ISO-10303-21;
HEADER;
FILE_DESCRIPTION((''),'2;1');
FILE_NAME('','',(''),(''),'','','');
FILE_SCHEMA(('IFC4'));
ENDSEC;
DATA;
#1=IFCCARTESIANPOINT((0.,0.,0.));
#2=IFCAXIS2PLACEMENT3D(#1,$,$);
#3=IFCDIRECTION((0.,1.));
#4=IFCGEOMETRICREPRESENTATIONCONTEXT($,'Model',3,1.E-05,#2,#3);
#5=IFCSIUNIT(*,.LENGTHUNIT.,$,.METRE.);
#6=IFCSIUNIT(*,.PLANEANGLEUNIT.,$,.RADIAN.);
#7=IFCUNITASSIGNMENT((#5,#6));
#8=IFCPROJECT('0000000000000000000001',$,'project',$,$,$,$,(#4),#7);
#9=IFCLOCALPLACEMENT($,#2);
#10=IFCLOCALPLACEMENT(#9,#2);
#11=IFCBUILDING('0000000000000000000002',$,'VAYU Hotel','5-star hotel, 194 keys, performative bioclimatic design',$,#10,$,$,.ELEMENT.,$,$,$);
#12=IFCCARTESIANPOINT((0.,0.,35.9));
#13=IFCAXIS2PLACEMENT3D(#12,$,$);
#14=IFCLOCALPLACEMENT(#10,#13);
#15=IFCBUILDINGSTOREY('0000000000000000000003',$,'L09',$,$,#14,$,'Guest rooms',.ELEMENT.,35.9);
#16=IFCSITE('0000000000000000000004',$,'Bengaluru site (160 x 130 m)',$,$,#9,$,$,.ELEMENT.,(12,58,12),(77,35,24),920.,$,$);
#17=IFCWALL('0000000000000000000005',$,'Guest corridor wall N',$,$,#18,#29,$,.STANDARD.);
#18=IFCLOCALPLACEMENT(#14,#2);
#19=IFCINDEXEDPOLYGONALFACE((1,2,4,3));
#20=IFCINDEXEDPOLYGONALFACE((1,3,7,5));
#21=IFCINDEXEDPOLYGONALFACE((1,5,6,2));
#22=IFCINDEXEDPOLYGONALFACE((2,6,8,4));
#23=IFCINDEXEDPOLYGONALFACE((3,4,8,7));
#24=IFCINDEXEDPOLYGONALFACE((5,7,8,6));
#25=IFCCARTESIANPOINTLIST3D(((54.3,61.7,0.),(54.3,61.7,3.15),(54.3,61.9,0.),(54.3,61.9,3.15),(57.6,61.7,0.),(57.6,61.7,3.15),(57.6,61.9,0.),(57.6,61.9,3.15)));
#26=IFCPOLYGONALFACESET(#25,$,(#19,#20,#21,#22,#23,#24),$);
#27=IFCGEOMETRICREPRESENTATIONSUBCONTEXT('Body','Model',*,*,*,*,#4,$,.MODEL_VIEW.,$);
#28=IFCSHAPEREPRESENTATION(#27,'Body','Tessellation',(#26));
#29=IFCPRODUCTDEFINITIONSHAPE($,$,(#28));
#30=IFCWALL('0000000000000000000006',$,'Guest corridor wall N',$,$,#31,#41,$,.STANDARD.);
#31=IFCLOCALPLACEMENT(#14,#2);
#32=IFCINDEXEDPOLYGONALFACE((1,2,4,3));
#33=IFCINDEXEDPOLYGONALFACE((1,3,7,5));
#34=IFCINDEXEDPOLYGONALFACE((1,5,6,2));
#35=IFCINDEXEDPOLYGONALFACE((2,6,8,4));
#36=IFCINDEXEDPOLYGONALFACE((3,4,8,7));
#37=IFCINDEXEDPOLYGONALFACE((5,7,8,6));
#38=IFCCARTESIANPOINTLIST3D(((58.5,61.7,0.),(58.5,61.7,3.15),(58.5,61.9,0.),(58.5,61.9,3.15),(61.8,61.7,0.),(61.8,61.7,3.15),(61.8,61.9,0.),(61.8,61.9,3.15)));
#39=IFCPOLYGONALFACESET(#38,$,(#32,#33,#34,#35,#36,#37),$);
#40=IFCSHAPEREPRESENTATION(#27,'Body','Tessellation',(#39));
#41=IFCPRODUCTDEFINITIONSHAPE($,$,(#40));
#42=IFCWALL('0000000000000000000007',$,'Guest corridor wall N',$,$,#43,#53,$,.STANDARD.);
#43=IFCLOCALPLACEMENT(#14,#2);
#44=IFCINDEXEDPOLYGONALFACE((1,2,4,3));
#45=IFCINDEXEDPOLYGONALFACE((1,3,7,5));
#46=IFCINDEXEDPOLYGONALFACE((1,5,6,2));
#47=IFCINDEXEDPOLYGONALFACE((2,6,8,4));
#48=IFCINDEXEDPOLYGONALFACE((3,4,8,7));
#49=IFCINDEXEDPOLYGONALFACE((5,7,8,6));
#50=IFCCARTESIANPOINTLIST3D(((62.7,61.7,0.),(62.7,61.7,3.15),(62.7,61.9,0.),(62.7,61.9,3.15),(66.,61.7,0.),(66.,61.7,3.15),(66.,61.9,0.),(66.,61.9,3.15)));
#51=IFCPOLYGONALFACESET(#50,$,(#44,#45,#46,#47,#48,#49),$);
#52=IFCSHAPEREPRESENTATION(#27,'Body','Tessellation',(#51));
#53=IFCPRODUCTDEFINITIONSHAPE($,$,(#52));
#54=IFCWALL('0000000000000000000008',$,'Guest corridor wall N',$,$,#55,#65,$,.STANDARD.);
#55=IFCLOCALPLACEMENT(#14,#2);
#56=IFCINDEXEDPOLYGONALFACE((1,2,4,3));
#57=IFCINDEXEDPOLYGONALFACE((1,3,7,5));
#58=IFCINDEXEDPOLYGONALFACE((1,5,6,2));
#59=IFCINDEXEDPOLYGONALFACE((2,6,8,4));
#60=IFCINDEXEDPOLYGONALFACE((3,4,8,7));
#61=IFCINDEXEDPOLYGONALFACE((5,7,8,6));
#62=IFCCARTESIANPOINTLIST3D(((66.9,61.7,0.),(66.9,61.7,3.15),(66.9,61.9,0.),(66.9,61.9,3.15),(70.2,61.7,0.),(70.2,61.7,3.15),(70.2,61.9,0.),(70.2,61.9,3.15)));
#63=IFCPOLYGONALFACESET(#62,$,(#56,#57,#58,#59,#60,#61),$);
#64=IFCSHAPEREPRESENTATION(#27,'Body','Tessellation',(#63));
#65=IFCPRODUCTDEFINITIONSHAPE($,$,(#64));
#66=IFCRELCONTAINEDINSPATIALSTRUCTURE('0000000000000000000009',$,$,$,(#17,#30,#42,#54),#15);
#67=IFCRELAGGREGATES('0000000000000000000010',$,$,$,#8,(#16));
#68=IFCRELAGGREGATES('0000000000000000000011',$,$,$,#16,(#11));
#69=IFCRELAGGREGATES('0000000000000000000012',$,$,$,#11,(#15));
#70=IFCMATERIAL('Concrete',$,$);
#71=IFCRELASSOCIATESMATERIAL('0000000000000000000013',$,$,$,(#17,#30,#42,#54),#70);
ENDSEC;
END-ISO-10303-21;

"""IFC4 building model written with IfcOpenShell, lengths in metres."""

from ifc_helpers import new_model, si_unit, direction, frame, origin, place, context, subcontext, project, spatial, polyline, outline, extrude, material, element, save


model = new_model("IFC4")

# Units and contexts
model_context = context("Model", 3, precision=1e-05, world=origin(), true_north=direction((0.0, 1.0)))
body_context = subcontext(model_context, "Body", "Model", "MODEL_VIEW")
ifc_project = project(units=[si_unit("LENGTHUNIT", "METRE"), si_unit("PLANEANGLEUNIT", "RADIAN")], contexts=[model_context])

# Site, building, storey
site_placement = place(None, origin())
site = spatial("IfcSite", under=ifc_project, at=site_placement, Name="Bengaluru site (160 x 130 m)", CompositionType="ELEMENT", RefLatitude=(12, 58, 12), RefLongitude=(77, 35, 24), RefElevation=920.0)
building_placement = place(site_placement, origin())
building = spatial("IfcBuilding", under=site, at=building_placement, Name="VAYU Hotel", Description="5-star hotel, 194 keys, performative bioclimatic design", CompositionType="ELEMENT")
storey_placement = place(building_placement, frame((0.0, 0.0, 35.9)))
storey = spatial("IfcBuildingStorey", under=building, at=storey_placement, Name="L09", LongName="Guest rooms", CompositionType="ELEMENT", Elevation=35.9)

# Shared definitions
ifc_material = material(Name="Concrete")

# Walls
wall_1_placement = place(storey_placement, origin())
element("IfcWall", 1, at=wall_1_placement, inside=storey, material=ifc_material, Name="Guest corridor wall N", PredefinedType="STANDARD", context=body_context, shape_type="SweptSolid", body=[
    extrude(outline(polyline([(54.3, 61.9), (57.6, 61.9), (57.6, 61.7), (54.3, 61.7), (54.3, 61.9)])), origin(), (0.0, 0.0, 1.0), 3.15),
])
wall_2_placement = place(storey_placement, origin())
element("IfcWall", 2, at=wall_2_placement, inside=storey, material=ifc_material, Name="Guest corridor wall N", PredefinedType="STANDARD", context=body_context, shape_type="SweptSolid", body=[
    extrude(outline(polyline([(58.5, 61.9), (61.8, 61.9), (61.8, 61.7), (58.5, 61.7), (58.5, 61.9)])), origin(), (0.0, 0.0, 1.0), 3.15),
])
wall_3_placement = place(storey_placement, origin())
element("IfcWall", 3, at=wall_3_placement, inside=storey, material=ifc_material, Name="Guest corridor wall N", PredefinedType="STANDARD", context=body_context, shape_type="SweptSolid", body=[
    extrude(outline(polyline([(62.7, 61.9), (66.0, 61.9), (66.0, 61.7), (62.7, 61.7), (62.7, 61.9)])), origin(), (0.0, 0.0, 1.0), 3.15),
])
wall_4_placement = place(storey_placement, origin())
element("IfcWall", 4, at=wall_4_placement, inside=storey, material=ifc_material, Name="Guest corridor wall N", PredefinedType="STANDARD", context=body_context, shape_type="SweptSolid", body=[
    extrude(outline(polyline([(66.9, 61.9), (70.2, 61.9), (70.2, 61.7), (66.9, 61.7), (66.9, 61.9)])), origin(), (0.0, 0.0, 1.0), 3.15),
])

save(model, "model.ifc")
